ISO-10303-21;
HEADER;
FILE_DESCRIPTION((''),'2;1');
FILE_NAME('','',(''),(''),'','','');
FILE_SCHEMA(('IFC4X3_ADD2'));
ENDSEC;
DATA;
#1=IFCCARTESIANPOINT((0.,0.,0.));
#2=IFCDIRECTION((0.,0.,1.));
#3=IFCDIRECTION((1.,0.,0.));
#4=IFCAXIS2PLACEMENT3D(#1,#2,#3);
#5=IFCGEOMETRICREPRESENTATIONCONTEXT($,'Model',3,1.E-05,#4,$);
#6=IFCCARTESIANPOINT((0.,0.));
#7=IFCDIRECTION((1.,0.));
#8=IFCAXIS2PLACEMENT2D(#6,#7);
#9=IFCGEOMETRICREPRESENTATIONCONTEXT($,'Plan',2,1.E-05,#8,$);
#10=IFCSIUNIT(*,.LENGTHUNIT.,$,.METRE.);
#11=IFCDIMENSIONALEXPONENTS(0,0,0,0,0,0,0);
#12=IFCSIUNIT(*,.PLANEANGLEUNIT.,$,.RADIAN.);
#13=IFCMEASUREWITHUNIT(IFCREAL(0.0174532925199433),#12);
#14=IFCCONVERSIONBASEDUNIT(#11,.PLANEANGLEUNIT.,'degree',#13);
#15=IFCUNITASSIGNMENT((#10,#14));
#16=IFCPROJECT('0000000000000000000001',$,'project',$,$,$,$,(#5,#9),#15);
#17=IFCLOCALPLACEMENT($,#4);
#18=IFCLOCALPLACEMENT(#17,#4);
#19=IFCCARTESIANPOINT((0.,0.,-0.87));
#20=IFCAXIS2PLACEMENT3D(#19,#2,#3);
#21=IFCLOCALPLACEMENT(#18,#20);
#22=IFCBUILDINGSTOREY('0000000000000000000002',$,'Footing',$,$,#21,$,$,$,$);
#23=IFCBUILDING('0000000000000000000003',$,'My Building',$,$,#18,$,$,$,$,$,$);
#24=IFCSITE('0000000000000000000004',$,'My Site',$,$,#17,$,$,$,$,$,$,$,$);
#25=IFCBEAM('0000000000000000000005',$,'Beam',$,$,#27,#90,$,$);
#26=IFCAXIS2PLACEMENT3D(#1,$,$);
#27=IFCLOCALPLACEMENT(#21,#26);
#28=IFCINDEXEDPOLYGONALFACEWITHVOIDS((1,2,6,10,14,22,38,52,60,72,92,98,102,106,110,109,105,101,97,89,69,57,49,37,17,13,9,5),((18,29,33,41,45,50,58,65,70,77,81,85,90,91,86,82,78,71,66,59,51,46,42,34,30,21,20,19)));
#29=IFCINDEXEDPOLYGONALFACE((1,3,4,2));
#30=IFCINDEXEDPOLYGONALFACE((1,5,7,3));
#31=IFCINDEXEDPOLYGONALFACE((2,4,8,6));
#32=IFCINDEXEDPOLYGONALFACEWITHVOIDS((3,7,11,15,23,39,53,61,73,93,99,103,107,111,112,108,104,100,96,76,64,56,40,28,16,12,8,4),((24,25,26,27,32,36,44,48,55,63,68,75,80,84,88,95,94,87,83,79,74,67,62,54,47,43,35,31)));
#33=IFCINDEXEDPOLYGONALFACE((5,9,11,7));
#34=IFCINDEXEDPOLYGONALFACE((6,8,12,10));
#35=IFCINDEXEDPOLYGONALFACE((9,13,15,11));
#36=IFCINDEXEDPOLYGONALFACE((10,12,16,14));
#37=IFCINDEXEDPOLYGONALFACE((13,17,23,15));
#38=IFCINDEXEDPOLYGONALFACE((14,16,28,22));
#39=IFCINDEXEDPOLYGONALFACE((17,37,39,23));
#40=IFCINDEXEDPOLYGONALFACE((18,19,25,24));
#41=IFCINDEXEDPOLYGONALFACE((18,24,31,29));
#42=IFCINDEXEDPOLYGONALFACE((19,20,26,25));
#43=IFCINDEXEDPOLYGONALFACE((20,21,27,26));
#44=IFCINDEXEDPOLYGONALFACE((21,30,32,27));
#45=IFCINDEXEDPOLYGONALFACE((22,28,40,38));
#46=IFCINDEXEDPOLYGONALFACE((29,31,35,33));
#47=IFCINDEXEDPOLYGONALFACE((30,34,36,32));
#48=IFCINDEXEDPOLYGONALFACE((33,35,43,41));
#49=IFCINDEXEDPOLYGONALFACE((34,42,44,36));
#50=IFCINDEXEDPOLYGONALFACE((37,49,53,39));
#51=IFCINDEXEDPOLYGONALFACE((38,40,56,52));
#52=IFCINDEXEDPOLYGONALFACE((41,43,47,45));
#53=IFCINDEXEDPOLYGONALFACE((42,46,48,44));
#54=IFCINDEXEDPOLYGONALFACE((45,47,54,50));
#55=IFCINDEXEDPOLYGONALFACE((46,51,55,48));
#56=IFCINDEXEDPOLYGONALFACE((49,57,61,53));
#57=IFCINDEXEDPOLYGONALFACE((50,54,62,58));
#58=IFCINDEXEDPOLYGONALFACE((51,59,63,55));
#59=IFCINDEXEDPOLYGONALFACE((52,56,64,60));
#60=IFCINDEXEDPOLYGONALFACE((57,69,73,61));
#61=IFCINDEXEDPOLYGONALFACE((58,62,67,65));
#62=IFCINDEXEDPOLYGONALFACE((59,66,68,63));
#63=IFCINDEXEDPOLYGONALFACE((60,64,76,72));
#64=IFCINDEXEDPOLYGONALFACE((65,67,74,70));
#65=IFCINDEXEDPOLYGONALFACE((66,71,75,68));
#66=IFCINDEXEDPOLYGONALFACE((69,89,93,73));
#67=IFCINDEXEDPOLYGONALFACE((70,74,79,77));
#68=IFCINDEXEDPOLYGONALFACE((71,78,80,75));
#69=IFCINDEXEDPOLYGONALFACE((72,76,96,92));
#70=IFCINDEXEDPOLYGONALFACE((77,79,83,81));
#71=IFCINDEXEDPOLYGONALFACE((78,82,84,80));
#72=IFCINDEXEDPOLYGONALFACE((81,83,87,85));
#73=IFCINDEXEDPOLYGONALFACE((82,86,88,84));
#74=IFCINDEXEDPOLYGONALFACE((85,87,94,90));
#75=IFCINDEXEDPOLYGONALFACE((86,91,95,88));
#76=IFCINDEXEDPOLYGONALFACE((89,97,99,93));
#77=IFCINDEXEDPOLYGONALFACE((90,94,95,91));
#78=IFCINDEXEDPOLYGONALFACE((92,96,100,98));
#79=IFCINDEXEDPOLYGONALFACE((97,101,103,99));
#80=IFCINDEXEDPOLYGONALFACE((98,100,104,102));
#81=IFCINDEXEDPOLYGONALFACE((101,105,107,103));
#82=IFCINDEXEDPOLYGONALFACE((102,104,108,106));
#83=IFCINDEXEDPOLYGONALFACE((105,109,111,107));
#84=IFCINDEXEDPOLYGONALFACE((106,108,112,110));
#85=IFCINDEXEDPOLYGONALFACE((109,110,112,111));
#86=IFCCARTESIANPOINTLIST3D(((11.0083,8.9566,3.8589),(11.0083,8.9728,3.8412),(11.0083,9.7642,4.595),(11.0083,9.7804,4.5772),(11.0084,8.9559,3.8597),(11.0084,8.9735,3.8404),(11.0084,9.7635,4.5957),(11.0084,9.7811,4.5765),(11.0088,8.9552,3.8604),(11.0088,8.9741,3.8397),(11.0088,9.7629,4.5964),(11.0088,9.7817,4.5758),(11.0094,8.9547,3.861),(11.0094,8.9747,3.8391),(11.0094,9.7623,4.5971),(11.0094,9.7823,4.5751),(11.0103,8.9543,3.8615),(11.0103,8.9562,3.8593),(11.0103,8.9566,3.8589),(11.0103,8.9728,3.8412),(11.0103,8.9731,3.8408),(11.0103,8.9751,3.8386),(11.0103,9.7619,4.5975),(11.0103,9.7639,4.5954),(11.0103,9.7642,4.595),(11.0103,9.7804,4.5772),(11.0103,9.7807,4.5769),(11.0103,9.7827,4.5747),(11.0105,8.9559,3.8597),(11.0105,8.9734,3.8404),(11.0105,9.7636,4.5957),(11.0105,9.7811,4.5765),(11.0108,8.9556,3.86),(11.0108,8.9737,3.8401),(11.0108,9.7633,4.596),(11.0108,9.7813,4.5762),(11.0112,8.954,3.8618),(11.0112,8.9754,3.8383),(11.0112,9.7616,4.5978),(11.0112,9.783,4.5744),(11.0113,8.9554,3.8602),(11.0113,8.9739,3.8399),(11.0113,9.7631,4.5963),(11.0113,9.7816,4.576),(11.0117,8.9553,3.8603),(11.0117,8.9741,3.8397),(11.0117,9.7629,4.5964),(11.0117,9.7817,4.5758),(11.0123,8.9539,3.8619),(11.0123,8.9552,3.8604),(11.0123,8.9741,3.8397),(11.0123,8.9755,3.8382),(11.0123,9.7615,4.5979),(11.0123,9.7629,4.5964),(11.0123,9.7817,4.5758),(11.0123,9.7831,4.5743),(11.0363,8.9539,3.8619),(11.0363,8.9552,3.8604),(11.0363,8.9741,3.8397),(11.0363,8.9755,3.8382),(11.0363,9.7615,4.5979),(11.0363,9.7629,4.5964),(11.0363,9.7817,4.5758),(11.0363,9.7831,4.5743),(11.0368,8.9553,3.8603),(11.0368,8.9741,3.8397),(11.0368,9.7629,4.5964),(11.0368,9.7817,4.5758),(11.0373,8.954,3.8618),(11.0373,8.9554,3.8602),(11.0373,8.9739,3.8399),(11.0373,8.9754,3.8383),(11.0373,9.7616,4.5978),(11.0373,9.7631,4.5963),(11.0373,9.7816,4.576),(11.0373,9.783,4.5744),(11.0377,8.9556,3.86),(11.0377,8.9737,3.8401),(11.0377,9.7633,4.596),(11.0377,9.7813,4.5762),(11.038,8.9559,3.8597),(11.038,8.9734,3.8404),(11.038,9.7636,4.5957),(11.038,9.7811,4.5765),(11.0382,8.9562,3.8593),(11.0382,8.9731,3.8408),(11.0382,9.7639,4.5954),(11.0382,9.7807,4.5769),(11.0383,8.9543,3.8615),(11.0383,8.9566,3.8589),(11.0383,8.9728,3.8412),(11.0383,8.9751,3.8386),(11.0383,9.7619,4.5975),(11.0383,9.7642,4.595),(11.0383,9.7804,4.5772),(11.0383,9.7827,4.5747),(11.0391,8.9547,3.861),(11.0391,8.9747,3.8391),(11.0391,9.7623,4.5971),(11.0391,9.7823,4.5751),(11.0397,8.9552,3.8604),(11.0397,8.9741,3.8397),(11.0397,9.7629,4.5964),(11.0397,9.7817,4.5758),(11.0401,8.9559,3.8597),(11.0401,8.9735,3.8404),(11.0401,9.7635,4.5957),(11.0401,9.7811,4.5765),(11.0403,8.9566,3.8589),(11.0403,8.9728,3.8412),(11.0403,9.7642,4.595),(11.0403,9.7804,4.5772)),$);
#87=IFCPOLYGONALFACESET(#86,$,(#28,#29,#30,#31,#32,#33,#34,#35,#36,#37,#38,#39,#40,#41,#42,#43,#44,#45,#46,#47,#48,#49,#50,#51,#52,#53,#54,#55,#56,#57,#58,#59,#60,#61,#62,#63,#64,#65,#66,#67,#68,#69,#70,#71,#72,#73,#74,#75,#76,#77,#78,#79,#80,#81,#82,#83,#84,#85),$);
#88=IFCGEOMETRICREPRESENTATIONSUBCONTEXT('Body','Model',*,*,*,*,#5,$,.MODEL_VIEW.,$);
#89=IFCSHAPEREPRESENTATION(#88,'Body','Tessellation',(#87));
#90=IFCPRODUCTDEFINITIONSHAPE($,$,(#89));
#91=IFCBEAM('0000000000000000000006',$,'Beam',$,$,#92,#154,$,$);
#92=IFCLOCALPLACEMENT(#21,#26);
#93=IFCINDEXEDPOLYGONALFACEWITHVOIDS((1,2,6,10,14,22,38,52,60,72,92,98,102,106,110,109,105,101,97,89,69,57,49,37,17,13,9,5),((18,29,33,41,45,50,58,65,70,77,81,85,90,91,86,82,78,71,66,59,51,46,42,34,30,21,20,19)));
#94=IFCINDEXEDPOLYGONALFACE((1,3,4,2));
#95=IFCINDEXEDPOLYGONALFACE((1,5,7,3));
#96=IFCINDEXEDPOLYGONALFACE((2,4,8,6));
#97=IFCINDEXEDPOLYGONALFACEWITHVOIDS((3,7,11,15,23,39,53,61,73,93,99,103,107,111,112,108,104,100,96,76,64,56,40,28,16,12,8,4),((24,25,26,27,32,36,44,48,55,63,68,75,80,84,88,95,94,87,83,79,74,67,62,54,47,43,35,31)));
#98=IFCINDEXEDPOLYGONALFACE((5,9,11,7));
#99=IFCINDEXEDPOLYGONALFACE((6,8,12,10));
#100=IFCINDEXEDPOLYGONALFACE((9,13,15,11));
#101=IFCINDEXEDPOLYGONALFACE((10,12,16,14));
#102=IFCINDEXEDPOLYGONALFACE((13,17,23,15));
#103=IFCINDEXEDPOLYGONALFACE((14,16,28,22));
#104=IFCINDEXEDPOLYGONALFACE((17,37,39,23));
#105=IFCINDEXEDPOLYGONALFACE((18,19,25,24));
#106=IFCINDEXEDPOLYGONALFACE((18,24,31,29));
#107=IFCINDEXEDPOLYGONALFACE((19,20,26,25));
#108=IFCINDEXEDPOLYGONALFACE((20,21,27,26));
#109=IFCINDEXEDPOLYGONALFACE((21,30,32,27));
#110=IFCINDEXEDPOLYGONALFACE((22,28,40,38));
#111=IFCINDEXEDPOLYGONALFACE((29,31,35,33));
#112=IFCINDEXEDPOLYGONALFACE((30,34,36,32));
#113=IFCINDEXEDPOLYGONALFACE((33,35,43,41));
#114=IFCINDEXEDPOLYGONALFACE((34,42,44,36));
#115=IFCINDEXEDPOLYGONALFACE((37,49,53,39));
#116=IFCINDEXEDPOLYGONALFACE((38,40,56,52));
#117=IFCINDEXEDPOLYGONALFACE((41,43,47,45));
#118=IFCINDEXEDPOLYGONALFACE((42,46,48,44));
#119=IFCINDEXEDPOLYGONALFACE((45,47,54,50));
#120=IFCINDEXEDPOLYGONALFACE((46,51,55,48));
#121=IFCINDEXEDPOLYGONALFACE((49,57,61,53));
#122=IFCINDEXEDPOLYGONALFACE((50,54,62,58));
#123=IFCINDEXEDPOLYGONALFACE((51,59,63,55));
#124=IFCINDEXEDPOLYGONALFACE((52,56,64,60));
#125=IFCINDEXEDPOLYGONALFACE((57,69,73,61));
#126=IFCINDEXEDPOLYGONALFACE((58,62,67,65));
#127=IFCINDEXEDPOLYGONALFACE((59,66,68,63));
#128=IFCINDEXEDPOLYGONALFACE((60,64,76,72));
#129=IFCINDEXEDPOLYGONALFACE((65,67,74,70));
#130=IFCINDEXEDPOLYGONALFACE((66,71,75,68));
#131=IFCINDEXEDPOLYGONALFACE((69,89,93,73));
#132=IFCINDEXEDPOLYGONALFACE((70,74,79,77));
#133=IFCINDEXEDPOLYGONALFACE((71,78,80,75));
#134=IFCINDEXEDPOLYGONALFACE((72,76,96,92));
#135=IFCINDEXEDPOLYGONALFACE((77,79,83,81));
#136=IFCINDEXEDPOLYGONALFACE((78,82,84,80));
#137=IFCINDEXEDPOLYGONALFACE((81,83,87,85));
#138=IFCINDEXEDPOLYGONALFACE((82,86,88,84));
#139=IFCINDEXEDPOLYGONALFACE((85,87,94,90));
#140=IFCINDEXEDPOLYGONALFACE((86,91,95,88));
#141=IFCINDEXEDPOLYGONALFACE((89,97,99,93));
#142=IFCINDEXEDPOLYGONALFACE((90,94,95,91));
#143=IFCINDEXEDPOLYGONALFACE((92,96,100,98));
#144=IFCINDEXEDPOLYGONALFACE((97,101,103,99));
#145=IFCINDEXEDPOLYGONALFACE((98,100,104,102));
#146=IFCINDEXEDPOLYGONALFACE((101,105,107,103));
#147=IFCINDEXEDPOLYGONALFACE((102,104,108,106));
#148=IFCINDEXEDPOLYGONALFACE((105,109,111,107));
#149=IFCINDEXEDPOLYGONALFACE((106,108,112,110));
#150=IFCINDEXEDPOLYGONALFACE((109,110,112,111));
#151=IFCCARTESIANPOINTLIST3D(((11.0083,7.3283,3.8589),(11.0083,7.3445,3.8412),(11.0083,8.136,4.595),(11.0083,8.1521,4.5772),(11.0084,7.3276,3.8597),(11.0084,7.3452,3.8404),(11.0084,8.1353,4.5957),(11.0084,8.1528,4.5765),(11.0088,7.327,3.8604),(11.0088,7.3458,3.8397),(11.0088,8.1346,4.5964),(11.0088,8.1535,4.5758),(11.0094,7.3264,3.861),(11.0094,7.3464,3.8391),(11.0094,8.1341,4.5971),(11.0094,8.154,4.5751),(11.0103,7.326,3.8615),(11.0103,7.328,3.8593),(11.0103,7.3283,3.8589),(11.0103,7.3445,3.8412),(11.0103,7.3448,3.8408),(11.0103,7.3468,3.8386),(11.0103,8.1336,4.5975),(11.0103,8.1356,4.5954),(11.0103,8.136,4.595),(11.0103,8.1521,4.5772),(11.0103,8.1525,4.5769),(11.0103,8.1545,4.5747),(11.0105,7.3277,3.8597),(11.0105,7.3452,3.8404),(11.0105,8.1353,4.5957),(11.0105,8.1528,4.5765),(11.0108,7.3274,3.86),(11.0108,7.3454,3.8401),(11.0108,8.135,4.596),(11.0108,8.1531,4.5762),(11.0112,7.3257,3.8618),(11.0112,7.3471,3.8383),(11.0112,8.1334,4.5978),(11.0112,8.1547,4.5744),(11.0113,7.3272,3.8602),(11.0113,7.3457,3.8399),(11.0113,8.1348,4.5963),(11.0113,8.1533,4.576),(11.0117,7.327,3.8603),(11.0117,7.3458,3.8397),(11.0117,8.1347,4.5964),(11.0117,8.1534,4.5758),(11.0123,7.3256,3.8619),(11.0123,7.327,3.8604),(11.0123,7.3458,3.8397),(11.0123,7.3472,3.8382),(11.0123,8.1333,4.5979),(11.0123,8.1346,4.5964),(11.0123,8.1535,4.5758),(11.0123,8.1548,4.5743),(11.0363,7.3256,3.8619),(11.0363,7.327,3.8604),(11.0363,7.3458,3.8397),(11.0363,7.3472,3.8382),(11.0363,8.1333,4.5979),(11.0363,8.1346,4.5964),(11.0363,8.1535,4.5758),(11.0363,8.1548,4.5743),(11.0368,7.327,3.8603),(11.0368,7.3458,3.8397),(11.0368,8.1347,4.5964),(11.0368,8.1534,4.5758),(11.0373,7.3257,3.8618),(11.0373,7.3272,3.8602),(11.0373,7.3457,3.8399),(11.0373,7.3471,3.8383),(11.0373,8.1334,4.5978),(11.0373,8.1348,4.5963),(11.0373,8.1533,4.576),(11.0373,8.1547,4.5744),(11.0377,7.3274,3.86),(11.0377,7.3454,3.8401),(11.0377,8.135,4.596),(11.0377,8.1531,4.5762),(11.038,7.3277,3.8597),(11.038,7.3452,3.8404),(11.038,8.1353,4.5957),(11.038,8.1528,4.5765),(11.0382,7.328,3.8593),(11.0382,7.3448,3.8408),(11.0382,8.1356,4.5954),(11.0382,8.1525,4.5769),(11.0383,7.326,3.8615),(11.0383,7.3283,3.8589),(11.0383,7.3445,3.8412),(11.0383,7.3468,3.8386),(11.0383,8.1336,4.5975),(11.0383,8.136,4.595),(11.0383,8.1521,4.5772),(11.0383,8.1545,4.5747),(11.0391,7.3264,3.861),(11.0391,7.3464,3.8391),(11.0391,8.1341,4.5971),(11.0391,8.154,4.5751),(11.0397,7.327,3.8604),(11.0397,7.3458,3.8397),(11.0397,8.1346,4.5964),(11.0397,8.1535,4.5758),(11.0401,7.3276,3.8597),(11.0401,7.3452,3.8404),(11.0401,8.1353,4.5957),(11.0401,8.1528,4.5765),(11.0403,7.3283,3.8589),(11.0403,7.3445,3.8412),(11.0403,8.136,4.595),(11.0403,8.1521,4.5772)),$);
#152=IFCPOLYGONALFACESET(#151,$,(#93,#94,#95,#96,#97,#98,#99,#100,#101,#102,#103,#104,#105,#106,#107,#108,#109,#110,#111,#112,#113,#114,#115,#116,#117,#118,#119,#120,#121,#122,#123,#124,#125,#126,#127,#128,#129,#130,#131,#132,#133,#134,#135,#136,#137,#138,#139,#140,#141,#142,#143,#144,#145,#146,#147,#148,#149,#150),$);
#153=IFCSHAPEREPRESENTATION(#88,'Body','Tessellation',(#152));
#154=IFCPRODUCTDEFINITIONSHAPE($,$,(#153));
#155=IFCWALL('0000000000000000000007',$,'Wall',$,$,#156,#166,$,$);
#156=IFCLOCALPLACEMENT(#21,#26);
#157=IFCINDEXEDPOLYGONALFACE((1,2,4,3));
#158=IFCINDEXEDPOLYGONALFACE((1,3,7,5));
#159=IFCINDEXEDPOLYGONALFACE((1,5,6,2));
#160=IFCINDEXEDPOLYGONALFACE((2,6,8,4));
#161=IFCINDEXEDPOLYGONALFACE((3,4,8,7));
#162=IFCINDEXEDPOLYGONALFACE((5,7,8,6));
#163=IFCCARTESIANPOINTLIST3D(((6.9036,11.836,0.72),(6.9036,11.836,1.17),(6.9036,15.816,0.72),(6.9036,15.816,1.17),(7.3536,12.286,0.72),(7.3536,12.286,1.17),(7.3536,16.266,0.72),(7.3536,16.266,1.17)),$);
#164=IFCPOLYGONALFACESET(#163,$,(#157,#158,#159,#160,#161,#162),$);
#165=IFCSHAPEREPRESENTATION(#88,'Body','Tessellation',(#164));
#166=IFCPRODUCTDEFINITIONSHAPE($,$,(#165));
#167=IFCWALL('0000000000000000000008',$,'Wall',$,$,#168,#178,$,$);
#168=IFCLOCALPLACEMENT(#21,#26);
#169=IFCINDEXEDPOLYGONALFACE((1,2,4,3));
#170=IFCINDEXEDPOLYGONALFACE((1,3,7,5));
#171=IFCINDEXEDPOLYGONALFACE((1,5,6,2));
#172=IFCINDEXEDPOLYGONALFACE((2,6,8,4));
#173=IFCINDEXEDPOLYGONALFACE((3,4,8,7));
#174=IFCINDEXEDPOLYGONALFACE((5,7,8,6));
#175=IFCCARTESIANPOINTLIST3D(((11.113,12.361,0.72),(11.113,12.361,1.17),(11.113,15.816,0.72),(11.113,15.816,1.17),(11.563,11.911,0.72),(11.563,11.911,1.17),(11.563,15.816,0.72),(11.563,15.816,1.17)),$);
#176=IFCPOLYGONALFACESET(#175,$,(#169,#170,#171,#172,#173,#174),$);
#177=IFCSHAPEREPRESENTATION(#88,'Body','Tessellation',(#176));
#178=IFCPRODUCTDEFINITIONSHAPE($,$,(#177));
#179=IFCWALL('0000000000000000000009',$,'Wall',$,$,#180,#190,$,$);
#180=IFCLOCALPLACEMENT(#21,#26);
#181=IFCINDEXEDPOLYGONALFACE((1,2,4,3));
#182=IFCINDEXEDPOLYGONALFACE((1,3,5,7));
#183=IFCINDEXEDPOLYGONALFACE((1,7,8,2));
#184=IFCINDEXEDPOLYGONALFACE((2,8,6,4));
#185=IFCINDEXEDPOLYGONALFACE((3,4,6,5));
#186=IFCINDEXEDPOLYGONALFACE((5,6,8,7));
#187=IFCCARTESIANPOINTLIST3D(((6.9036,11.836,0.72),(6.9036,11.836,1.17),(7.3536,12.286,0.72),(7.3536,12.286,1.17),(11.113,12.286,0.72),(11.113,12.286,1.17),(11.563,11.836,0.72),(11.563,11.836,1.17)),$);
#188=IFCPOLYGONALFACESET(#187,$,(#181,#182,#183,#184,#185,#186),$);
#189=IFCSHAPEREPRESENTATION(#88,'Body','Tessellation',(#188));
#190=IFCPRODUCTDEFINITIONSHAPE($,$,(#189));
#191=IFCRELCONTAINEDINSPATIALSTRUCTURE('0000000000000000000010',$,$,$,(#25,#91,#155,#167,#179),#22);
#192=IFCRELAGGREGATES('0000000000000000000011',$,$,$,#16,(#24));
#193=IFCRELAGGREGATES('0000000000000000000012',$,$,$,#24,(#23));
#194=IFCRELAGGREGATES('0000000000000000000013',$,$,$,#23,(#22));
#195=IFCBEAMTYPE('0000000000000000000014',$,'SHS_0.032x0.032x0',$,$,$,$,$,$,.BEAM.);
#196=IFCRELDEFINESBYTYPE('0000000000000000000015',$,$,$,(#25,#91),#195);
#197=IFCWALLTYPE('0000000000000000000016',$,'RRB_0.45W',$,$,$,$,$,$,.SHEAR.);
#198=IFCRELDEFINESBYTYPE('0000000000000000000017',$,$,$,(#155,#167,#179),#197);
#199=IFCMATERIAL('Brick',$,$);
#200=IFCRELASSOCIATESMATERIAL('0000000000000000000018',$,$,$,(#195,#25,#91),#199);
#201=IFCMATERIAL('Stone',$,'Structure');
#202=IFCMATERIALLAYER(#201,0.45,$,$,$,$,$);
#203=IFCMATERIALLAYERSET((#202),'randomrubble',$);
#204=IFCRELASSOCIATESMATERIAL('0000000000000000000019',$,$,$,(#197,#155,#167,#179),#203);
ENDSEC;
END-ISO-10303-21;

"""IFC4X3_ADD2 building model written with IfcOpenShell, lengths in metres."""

from ifc_helpers import new_model, entity, si_unit, converted_unit, frame, origin_with_axes, origin_2d_with_axis, place, context, subcontext, project, spatial, line, indexed_curve, hollow_rectangle, outline, extrude, material, layer, layer_set, layer_usage, material_profile, profile_set, profile_usage, type_object, element, save


model = new_model("IFC4X3_ADD2")

# Units and contexts
model_context = context("Model", 3, precision=1e-05, world=origin_with_axes())
plan_context = context("Plan", 2, precision=1e-05, world=origin_2d_with_axis())
body_context = subcontext(model_context, "Body", "Model", "MODEL_VIEW")
ifc_project = project(units=[si_unit("LENGTHUNIT", "METRE"), converted_unit("PLANEANGLEUNIT", "degree", entity("IfcReal", 0.0174532925199433), si_unit("PLANEANGLEUNIT", "RADIAN"), dimensions=[0, 0, 0, 0, 0, 0, 0])], contexts=[model_context, plan_context])

# Site, building, storey
site_placement = place(None, origin_with_axes())
site = spatial("IfcSite", under=ifc_project, at=site_placement, Name="My Site")
building_placement = place(site_placement, origin_with_axes())
building = spatial("IfcBuilding", under=site, at=building_placement, Name="My Building")
storey_placement = place(building_placement, frame((0.0, 0.0, -0.87), z_axis=(0.0, 0.0, 1.0), x_axis=(1.0, 0.0, 0.0)))
storey = spatial("IfcBuildingStorey", under=building, at=storey_placement, Name="Footing")

# Beams
ifc_material_1 = material(Name="Stone", Category="Structure")
ifc_material_2 = material(Name="Brick")
ifc_material_profile = material_profile(ifc_material_2, hollow_rectangle(XDim=0.032, YDim=0.032, WallThickness=0.002, InnerFilletRadius=0.002, OuterFilletRadius=0.004))
ifc_profile_set = profile_set([ifc_material_profile])
beam_type_1 = type_object("IfcBeamType", Name="SHS_0.032x0.032x0", PredefinedType="BEAM", material=ifc_profile_set)
ifc_profile_usage_1 = profile_usage(ifc_profile_set, cardinal=5)
beam_1_placement = place(storey_placement, frame((11.0243, 9.7723, 4.5861), z_axis=(0.0, -0.739099, -0.673597), x_axis=(1.0, 0.0, 0.0)))
element("IfcBeam", 1, at=beam_1_placement, inside=storey, type_object=beam_type_1, material=ifc_profile_usage_1, Name="Beam", context=body_context, shape_type="SweptSolid", body=[
    extrude(hollow_rectangle(XDim=0.032, YDim=0.032, WallThickness=0.002, InnerFilletRadius=0.002, OuterFilletRadius=0.004), origin_with_axes(), (0.0, 0.0, 1.0), 1.0927),
])
ifc_profile_usage_2 = profile_usage(ifc_profile_set, cardinal=5)
beam_2_placement = place(storey_placement, frame((11.0243, 8.144, 4.5861), z_axis=(0.0, -0.739099, -0.673597), x_axis=(1.0, 0.0, 0.0)))
element("IfcBeam", 2, at=beam_2_placement, inside=storey, type_object=beam_type_1, material=ifc_profile_usage_2, Name="Beam", context=body_context, shape_type="SweptSolid", body=[
    extrude(hollow_rectangle(XDim=0.032, YDim=0.032, WallThickness=0.002, InnerFilletRadius=0.002, OuterFilletRadius=0.004), origin_with_axes(), (0.0, 0.0, 1.0), 1.0927),
])

# Walls
ifc_layer_1 = layer(ifc_material_1, 0.45)
ifc_layer_set_1 = layer_set([ifc_layer_1], Name="randomrubble")
ifc_layer_usage_1 = layer_usage(ifc_layer_set_1, "AXIS2", "POSITIVE", 0.0)
wall_type_1 = type_object("IfcWallType", Name="RRB_0.45W", PredefinedType="SHEAR", material=ifc_layer_set_1)
wall_1_placement = place(storey_placement, frame((7.3536, 12.286, 0.72), z_axis=(0.0, 0.0, 1.0), x_axis=(0.0, 1.0, 0.0)))
element("IfcWall", 3, at=wall_1_placement, inside=storey, type_object=wall_type_1, material=ifc_layer_usage_1, Name="Wall", context=body_context, shape_type="SweptSolid", body=[
    extrude(outline(indexed_curve([(0.0, 0.0), (-0.45, 0.45), (3.53, 0.45), (3.98, 0.0)], segments=[line(1, 2, 3, 4, 1)])), origin_with_axes(), (0.0, 0.0, 1.0), 0.45),
])
ifc_layer_usage_2 = layer_usage(ifc_layer_set_1, "AXIS2", "POSITIVE", 0.0)
wall_2_placement = place(storey_placement, frame((11.563, 12.361, 0.72), z_axis=(0.0, 0.0, 1.0), x_axis=(0.0, 1.0, 0.0)))
element("IfcWall", 4, at=wall_2_placement, inside=storey, type_object=wall_type_1, material=ifc_layer_usage_2, Name="Wall", context=body_context, shape_type="SweptSolid", body=[
    extrude(outline(indexed_curve([(-0.45, 0.0), (0.0, 0.45), (3.455, 0.45), (3.455, 0.0)], segments=[line(1, 2, 3, 4, 1)])), origin_with_axes(), (0.0, 0.0, 1.0), 0.45),
])
ifc_layer_usage_3 = layer_usage(ifc_layer_set_1, "AXIS2", "POSITIVE", 0.0)
wall_3_placement = place(storey_placement, frame((11.563, 12.286, 0.72), z_axis=(0.0, 0.0, 1.0), x_axis=(-1.0, 0.0, 0.0)))
element("IfcWall", 5, at=wall_3_placement, inside=storey, type_object=wall_type_1, material=ifc_layer_usage_3, Name="Wall", context=body_context, shape_type="SweptSolid", body=[
    extrude(outline(indexed_curve([(0.45, 0.0), (0.0, 0.45), (4.6594, 0.45), (4.2094, 0.0)], segments=[line(1, 2, 3, 4, 1)])), origin_with_axes(), (0.0, 0.0, 1.0), 0.45),
])

save(model, "model.ifc")
